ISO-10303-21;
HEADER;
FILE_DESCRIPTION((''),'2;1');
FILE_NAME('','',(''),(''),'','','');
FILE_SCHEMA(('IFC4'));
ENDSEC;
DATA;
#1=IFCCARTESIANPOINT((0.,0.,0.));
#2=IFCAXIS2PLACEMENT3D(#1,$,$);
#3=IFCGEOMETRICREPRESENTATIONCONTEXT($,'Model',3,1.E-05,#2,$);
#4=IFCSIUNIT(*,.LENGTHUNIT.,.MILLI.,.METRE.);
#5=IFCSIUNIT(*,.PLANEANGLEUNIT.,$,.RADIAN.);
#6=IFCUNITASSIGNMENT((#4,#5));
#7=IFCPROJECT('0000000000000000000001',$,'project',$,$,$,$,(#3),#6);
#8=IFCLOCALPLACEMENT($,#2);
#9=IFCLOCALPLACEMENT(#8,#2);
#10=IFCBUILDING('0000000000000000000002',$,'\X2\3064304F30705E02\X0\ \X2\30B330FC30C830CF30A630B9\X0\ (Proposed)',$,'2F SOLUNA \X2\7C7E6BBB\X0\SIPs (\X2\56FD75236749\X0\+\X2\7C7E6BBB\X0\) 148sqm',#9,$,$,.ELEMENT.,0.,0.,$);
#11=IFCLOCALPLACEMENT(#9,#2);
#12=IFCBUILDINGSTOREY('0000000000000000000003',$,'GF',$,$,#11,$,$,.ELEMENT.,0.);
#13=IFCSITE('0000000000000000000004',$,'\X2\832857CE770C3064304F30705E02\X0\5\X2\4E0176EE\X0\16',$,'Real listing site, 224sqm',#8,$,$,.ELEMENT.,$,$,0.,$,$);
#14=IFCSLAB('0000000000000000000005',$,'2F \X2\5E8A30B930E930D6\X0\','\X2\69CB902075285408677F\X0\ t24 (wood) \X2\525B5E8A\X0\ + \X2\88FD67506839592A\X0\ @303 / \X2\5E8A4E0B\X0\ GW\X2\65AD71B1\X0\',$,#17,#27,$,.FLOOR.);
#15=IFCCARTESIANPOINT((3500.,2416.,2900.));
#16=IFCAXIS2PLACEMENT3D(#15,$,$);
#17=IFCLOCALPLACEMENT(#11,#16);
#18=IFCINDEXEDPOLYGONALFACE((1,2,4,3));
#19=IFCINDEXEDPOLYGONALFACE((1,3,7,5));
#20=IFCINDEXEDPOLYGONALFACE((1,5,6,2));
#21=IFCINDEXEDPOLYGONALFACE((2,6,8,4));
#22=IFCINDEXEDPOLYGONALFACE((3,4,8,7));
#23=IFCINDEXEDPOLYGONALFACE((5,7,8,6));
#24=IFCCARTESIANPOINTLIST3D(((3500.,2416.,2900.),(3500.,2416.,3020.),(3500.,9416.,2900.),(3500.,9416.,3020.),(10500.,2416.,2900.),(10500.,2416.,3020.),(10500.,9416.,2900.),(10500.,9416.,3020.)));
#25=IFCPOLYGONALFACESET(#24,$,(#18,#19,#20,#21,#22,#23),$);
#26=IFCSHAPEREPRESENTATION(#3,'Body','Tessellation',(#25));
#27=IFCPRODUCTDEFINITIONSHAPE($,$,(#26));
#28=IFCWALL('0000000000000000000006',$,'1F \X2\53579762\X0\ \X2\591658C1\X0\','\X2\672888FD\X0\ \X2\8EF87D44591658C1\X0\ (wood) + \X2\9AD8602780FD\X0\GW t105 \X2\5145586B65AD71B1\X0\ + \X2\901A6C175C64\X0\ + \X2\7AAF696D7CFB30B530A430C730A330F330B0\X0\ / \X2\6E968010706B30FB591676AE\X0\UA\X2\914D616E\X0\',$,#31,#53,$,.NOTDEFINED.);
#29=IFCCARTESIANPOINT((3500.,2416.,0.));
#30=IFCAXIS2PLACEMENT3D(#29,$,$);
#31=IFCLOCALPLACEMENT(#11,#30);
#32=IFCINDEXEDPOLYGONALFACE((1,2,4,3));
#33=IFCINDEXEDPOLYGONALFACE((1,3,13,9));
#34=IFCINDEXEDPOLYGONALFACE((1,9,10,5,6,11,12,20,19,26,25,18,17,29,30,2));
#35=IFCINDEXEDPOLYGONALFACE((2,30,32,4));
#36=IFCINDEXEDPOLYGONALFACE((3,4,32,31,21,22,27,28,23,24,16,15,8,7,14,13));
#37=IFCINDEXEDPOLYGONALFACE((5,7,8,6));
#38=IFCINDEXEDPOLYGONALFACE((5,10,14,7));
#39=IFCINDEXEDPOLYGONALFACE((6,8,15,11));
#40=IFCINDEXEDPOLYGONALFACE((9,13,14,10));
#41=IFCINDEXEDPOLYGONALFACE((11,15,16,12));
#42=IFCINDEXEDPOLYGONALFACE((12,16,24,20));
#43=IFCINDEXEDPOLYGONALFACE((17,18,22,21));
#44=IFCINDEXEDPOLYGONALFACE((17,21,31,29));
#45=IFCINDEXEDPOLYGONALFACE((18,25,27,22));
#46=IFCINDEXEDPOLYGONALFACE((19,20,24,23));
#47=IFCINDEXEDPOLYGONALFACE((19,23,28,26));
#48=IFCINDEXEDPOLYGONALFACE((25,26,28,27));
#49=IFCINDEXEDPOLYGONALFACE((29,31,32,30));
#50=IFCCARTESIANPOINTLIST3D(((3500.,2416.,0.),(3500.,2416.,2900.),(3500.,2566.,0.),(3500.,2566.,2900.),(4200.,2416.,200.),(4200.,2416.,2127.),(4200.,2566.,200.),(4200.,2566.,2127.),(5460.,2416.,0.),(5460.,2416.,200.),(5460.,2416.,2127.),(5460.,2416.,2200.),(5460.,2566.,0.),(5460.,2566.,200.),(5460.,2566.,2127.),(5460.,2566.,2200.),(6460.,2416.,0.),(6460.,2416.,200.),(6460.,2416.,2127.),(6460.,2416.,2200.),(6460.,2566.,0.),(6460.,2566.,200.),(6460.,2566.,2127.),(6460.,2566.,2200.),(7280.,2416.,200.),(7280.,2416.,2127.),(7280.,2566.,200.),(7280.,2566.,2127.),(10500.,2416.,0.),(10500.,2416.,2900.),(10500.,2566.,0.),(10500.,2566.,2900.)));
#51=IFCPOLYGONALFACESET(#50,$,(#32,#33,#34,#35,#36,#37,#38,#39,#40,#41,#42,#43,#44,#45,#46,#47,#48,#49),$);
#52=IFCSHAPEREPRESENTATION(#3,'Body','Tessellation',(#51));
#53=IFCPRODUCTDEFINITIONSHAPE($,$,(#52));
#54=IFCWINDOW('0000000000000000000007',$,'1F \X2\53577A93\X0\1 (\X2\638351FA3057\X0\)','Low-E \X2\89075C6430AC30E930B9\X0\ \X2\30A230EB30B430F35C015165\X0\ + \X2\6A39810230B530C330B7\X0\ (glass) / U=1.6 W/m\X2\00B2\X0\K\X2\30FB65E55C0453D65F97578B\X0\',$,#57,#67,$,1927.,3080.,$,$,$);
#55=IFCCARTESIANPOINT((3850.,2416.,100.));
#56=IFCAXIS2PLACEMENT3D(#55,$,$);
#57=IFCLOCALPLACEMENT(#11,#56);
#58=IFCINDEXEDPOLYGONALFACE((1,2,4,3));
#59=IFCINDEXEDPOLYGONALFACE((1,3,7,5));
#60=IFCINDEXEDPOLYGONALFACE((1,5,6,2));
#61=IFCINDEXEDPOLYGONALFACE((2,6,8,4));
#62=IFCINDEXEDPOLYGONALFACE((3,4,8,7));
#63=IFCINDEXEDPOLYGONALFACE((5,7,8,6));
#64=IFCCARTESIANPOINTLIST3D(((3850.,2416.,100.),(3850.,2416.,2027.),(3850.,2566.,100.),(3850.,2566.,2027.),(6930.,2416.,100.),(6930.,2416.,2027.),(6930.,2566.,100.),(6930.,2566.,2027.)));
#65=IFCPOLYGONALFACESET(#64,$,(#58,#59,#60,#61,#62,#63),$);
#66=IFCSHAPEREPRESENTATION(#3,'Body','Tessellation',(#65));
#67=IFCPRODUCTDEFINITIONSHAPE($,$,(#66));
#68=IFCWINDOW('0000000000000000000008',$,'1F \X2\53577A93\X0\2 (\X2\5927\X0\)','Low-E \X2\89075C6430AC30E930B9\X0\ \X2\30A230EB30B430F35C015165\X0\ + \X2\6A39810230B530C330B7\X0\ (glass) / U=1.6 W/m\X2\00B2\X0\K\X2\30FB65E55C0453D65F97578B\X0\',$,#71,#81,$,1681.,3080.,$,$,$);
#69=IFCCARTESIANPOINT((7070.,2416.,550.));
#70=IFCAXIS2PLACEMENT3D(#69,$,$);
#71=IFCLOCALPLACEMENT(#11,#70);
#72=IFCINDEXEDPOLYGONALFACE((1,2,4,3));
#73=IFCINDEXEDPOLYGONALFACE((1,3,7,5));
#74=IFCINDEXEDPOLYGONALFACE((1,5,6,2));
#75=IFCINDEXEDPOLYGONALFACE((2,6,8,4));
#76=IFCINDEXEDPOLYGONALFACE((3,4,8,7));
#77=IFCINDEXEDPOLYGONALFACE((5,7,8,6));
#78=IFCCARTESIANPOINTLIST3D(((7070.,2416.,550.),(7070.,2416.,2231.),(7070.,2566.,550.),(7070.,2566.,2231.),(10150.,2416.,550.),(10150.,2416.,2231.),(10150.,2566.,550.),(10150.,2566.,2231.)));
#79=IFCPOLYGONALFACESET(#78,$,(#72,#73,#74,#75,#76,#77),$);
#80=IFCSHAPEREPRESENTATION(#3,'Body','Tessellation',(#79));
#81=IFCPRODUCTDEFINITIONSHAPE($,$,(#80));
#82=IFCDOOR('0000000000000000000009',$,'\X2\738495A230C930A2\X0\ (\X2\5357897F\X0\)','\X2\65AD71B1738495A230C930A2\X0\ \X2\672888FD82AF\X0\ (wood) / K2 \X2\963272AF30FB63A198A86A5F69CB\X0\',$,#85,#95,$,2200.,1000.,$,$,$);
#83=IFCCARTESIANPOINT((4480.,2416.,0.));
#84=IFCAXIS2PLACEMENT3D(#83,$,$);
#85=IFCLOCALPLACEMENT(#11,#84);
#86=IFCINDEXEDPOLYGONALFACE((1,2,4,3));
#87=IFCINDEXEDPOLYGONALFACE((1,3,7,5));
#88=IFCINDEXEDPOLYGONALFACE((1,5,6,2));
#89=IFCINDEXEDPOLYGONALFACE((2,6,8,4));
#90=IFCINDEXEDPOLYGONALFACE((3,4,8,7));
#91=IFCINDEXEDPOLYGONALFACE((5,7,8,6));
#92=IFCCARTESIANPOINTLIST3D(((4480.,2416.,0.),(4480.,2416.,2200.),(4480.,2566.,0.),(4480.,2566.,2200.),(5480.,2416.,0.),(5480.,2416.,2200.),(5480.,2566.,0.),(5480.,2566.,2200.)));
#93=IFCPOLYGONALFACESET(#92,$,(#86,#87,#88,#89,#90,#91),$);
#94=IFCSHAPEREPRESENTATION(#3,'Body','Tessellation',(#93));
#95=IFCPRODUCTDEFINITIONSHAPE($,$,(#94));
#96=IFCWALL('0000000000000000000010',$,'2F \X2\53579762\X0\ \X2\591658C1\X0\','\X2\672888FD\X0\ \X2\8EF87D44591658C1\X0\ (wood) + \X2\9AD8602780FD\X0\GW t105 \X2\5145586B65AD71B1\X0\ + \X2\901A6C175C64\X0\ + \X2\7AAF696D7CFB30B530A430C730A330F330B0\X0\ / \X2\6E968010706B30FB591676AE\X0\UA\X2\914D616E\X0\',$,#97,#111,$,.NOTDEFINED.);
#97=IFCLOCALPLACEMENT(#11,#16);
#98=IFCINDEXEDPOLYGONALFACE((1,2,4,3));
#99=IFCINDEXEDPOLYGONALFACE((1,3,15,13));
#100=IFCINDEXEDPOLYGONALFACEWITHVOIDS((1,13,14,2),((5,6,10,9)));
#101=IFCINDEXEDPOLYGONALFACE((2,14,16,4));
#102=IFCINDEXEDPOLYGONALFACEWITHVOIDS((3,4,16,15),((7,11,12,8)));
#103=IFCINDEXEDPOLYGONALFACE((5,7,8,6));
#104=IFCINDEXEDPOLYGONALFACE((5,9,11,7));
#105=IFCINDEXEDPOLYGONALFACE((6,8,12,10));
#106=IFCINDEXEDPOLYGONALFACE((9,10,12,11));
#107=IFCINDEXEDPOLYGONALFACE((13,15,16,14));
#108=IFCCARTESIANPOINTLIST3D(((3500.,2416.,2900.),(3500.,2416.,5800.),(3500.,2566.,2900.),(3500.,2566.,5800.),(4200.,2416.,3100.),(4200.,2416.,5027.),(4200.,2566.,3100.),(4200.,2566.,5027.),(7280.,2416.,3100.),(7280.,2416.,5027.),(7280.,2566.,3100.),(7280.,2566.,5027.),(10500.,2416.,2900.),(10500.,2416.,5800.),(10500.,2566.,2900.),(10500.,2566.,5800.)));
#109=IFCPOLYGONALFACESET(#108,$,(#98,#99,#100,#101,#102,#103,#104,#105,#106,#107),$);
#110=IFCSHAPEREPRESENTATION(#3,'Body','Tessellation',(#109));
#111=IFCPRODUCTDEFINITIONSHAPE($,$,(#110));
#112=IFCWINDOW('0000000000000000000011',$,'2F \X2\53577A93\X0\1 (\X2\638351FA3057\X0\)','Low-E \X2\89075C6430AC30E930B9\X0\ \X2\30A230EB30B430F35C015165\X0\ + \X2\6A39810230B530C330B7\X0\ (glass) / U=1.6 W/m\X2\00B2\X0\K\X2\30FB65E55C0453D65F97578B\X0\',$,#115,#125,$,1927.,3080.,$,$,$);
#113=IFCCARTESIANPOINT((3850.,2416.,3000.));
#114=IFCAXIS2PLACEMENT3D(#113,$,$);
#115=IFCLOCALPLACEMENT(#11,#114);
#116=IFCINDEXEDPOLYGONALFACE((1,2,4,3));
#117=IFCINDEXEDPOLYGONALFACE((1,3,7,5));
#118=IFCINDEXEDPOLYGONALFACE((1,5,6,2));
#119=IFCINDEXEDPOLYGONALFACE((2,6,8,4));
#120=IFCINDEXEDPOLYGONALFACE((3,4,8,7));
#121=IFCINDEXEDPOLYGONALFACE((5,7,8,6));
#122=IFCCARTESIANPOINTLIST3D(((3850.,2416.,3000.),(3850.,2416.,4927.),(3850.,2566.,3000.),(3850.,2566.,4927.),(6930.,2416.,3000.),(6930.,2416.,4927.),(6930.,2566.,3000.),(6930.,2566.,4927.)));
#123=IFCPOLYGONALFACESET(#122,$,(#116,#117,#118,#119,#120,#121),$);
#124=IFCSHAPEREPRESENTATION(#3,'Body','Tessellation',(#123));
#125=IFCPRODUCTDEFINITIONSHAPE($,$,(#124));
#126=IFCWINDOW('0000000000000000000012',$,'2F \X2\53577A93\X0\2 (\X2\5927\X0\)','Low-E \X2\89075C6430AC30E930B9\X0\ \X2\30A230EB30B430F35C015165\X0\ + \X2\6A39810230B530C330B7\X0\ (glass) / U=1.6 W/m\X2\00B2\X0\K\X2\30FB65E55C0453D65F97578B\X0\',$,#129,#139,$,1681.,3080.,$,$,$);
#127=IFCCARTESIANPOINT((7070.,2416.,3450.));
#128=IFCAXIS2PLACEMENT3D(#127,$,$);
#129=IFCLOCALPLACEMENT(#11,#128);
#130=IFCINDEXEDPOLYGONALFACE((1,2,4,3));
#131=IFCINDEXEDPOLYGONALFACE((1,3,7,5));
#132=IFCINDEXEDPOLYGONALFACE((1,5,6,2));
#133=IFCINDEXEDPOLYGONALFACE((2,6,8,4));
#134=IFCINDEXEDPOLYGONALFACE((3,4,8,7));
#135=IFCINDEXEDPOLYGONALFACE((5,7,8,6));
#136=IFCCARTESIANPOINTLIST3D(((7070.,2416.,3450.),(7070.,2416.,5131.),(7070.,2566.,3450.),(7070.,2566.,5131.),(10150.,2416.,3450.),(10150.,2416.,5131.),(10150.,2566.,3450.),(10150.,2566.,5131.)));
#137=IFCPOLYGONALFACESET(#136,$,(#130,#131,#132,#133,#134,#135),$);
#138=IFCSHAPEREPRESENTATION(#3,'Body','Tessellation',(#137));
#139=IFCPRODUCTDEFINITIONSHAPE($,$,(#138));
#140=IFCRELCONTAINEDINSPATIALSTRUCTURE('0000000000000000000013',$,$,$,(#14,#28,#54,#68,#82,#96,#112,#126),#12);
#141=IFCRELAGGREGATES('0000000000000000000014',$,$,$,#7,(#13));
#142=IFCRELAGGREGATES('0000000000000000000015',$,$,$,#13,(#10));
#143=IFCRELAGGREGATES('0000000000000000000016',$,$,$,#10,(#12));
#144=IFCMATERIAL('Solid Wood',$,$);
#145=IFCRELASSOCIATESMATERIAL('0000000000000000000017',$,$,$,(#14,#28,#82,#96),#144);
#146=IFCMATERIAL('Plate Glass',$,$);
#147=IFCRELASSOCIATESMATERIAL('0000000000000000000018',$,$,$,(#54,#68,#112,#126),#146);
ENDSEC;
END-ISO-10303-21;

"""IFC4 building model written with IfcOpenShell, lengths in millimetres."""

from ifc_helpers import new_model, si_unit, frame, frame_2d, origin, place, context, project, spatial, rectangle, extrude, material, element, fill, save


model = new_model("IFC4")

# Units and contexts
model_context = context("Model", 3, precision=1e-05, world=origin())
ifc_project = project(units=[si_unit("LENGTHUNIT", "METRE", prefix="MILLI"), si_unit("PLANEANGLEUNIT", "RADIAN")], contexts=[model_context])

# Site, building, storey
site_placement = place(None, origin())
site = spatial("IfcSite", under=ifc_project, at=site_placement, Name="茨城県つくば市5丁目16", ObjectType="Real listing site, 224sqm", CompositionType="ELEMENT", RefElevation=0.0)
building_placement = place(site_placement, origin())
building = spatial("IfcBuilding", under=site, at=building_placement, Name="つくば市 コートハウス (Proposed)", ObjectType="2F SOLUNA 籾殻SIPs (国産杉+籾殻) 148sqm", CompositionType="ELEMENT", ElevationOfRefHeight=0.0, ElevationOfTerrain=0.0)
storey_placement = place(building_placement, origin())
storey = spatial("IfcBuildingStorey", under=building, at=storey_placement, Name="GF", CompositionType="ELEMENT", Elevation=0.0)

# Slab
ifc_material_1 = material(Name="Solid Wood")
slab_1_placement = place(storey_placement, frame((3500.0, 2416.0, 2900.0)))
element("IfcSlab", 1, at=slab_1_placement, inside=storey, material=ifc_material_1, Name="2F 床スラブ", Description="構造用合板 t24 (wood) 剛床 + 製材根太 @303 / 床下 GW断熱", PredefinedType="FLOOR", context=model_context, shape_type="SweptSolid", body=[
    extrude(rectangle(XDim=7000.0, YDim=7000.0, at=frame_2d((3500.0, 3500.0))), frame((3500.0, 2416.0, 2900.0)), (0.0, 0.0, 1.0), 120.0),
])

# Wall, openings, windows, door
wall_1_placement = place(storey_placement, frame((3500.0, 2416.0, 0.0)))
wall_1 = element("IfcWall", 2, at=wall_1_placement, inside=storey, material=ifc_material_1, Name="1F 南面 外壁", Description="木製 軸組外壁 (wood) + 高性能GW t105 充填断熱 + 通気層 + 窯業系サイディング / 準耐火・外皮UA配慮", PredefinedType="NOTDEFINED", context=model_context, shape_type="SweptSolid", body=[
    extrude(rectangle(XDim=7000.0, YDim=150.0, at=frame_2d((3500.0, 75.0))), frame((3500.0, 2416.0, 0.0)), (0.0, 0.0, 1.0), 2900.0),
])
opening_1_placement = place(storey_placement, frame((3850.0, 2416.0, 100.0)))
opening_1 = element("IfcOpeningElement", 3, at=opening_1_placement, cuts=wall_1, PredefinedType="NOTDEFINED", context=model_context, shape_type="SweptSolid", body=[
    extrude(rectangle(XDim=3080.0, YDim=150.0, at=frame_2d((1540.0, 75.0))), frame((3850.0, 2416.0, 100.0)), (0.0, 0.0, 1.0), 1927.0),
])
opening_2_placement = place(storey_placement, frame((7070.0, 2416.0, 550.0)))
opening_2 = element("IfcOpeningElement", 4, at=opening_2_placement, cuts=wall_1, PredefinedType="NOTDEFINED", context=model_context, shape_type="SweptSolid", body=[
    extrude(rectangle(XDim=3080.0, YDim=150.0, at=frame_2d((1540.0, 75.0))), frame((7070.0, 2416.0, 550.0)), (0.0, 0.0, 1.0), 1681.0),
])
opening_3_placement = place(storey_placement, frame((4480.0, 2416.0, 0.0)))
opening_3 = element("IfcOpeningElement", 5, at=opening_3_placement, cuts=wall_1, PredefinedType="NOTDEFINED", context=model_context, shape_type="SweptSolid", body=[
    extrude(rectangle(XDim=1000.0, YDim=150.0, at=frame_2d((500.0, 75.0))), frame((4480.0, 2416.0, 0.0)), (0.0, 0.0, 1.0), 2200.0),
])
ifc_material_2 = material(Name="Plate Glass")
window_1_placement = place(storey_placement, frame((3850.0, 2416.0, 100.0)))
window_1 = element("IfcWindow", 6, at=window_1_placement, inside=storey, material=ifc_material_2, Name="1F 南窓1 (掃出し)", Description="Low-E 複層ガラス アルゴン封入 + 樹脂サッシ (glass) / U=1.6 W/m²K・日射取得型", OverallHeight=1927.0, OverallWidth=3080.0, context=model_context, shape_type="SweptSolid", body=[
    extrude(rectangle(XDim=3080.0, YDim=150.0, at=frame_2d((1540.0, 75.0))), frame((3850.0, 2416.0, 100.0)), (0.0, 0.0, 1.0), 1927.0),
])
fill(opening_1, window_1)
window_2_placement = place(storey_placement, frame((7070.0, 2416.0, 550.0)))
window_2 = element("IfcWindow", 7, at=window_2_placement, inside=storey, material=ifc_material_2, Name="1F 南窓2 (大)", Description="Low-E 複層ガラス アルゴン封入 + 樹脂サッシ (glass) / U=1.6 W/m²K・日射取得型", OverallHeight=1681.0, OverallWidth=3080.0, context=model_context, shape_type="SweptSolid", body=[
    extrude(rectangle(XDim=3080.0, YDim=150.0, at=frame_2d((1540.0, 75.0))), frame((7070.0, 2416.0, 550.0)), (0.0, 0.0, 1.0), 1681.0),
])
fill(opening_2, window_2)
door_placement = place(storey_placement, frame((4480.0, 2416.0, 0.0)))
door = element("IfcDoor", 8, at=door_placement, inside=storey, material=ifc_material_1, Name="玄関ドア (南西)", Description="断熱玄関ドア 木製芯 (wood) / K2 防犯・採風機構", OverallHeight=2200.0, OverallWidth=1000.0, context=model_context, shape_type="SweptSolid", body=[
    extrude(rectangle(XDim=1000.0, YDim=150.0, at=frame_2d((500.0, 75.0))), frame((4480.0, 2416.0, 0.0)), (0.0, 0.0, 1.0), 2200.0),
])
fill(opening_3, door)

# Wall, openings, windows
wall_2_placement = place(storey_placement, frame((3500.0, 2416.0, 2900.0)))
wall_2 = element("IfcWall", 9, at=wall_2_placement, inside=storey, material=ifc_material_1, Name="2F 南面 外壁", Description="木製 軸組外壁 (wood) + 高性能GW t105 充填断熱 + 通気層 + 窯業系サイディング / 準耐火・外皮UA配慮", PredefinedType="NOTDEFINED", context=model_context, shape_type="SweptSolid", body=[
    extrude(rectangle(XDim=7000.0, YDim=150.0, at=frame_2d((3500.0, 75.0))), frame((3500.0, 2416.0, 2900.0)), (0.0, 0.0, 1.0), 2900.0),
])
opening_4_placement = place(storey_placement, frame((3850.0, 2416.0, 3000.0)))
opening_4 = element("IfcOpeningElement", 10, at=opening_4_placement, cuts=wall_2, PredefinedType="NOTDEFINED", context=model_context, shape_type="SweptSolid", body=[
    extrude(rectangle(XDim=3080.0, YDim=150.0, at=frame_2d((1540.0, 75.0))), frame((3850.0, 2416.0, 3000.0)), (0.0, 0.0, 1.0), 1927.0),
])
opening_5_placement = place(storey_placement, frame((7070.0, 2416.0, 3450.0)))
opening_5 = element("IfcOpeningElement", 11, at=opening_5_placement, cuts=wall_2, PredefinedType="NOTDEFINED", context=model_context, shape_type="SweptSolid", body=[
    extrude(rectangle(XDim=3080.0, YDim=150.0, at=frame_2d((1540.0, 75.0))), frame((7070.0, 2416.0, 3450.0)), (0.0, 0.0, 1.0), 1681.0),
])
window_3_placement = place(storey_placement, frame((3850.0, 2416.0, 3000.0)))
window_3 = element("IfcWindow", 12, at=window_3_placement, inside=storey, material=ifc_material_2, Name="2F 南窓1 (掃出し)", Description="Low-E 複層ガラス アルゴン封入 + 樹脂サッシ (glass) / U=1.6 W/m²K・日射取得型", OverallHeight=1927.0, OverallWidth=3080.0, context=model_context, shape_type="SweptSolid", body=[
    extrude(rectangle(XDim=3080.0, YDim=150.0, at=frame_2d((1540.0, 75.0))), frame((3850.0, 2416.0, 3000.0)), (0.0, 0.0, 1.0), 1927.0),
])
fill(opening_4, window_3)
window_4_placement = place(storey_placement, frame((7070.0, 2416.0, 3450.0)))
window_4 = element("IfcWindow", 13, at=window_4_placement, inside=storey, material=ifc_material_2, Name="2F 南窓2 (大)", Description="Low-E 複層ガラス アルゴン封入 + 樹脂サッシ (glass) / U=1.6 W/m²K・日射取得型", OverallHeight=1681.0, OverallWidth=3080.0, context=model_context, shape_type="SweptSolid", body=[
    extrude(rectangle(XDim=3080.0, YDim=150.0, at=frame_2d((1540.0, 75.0))), frame((7070.0, 2416.0, 3450.0)), (0.0, 0.0, 1.0), 1681.0),
])
fill(opening_5, window_4)

save(model, "model.ifc")
